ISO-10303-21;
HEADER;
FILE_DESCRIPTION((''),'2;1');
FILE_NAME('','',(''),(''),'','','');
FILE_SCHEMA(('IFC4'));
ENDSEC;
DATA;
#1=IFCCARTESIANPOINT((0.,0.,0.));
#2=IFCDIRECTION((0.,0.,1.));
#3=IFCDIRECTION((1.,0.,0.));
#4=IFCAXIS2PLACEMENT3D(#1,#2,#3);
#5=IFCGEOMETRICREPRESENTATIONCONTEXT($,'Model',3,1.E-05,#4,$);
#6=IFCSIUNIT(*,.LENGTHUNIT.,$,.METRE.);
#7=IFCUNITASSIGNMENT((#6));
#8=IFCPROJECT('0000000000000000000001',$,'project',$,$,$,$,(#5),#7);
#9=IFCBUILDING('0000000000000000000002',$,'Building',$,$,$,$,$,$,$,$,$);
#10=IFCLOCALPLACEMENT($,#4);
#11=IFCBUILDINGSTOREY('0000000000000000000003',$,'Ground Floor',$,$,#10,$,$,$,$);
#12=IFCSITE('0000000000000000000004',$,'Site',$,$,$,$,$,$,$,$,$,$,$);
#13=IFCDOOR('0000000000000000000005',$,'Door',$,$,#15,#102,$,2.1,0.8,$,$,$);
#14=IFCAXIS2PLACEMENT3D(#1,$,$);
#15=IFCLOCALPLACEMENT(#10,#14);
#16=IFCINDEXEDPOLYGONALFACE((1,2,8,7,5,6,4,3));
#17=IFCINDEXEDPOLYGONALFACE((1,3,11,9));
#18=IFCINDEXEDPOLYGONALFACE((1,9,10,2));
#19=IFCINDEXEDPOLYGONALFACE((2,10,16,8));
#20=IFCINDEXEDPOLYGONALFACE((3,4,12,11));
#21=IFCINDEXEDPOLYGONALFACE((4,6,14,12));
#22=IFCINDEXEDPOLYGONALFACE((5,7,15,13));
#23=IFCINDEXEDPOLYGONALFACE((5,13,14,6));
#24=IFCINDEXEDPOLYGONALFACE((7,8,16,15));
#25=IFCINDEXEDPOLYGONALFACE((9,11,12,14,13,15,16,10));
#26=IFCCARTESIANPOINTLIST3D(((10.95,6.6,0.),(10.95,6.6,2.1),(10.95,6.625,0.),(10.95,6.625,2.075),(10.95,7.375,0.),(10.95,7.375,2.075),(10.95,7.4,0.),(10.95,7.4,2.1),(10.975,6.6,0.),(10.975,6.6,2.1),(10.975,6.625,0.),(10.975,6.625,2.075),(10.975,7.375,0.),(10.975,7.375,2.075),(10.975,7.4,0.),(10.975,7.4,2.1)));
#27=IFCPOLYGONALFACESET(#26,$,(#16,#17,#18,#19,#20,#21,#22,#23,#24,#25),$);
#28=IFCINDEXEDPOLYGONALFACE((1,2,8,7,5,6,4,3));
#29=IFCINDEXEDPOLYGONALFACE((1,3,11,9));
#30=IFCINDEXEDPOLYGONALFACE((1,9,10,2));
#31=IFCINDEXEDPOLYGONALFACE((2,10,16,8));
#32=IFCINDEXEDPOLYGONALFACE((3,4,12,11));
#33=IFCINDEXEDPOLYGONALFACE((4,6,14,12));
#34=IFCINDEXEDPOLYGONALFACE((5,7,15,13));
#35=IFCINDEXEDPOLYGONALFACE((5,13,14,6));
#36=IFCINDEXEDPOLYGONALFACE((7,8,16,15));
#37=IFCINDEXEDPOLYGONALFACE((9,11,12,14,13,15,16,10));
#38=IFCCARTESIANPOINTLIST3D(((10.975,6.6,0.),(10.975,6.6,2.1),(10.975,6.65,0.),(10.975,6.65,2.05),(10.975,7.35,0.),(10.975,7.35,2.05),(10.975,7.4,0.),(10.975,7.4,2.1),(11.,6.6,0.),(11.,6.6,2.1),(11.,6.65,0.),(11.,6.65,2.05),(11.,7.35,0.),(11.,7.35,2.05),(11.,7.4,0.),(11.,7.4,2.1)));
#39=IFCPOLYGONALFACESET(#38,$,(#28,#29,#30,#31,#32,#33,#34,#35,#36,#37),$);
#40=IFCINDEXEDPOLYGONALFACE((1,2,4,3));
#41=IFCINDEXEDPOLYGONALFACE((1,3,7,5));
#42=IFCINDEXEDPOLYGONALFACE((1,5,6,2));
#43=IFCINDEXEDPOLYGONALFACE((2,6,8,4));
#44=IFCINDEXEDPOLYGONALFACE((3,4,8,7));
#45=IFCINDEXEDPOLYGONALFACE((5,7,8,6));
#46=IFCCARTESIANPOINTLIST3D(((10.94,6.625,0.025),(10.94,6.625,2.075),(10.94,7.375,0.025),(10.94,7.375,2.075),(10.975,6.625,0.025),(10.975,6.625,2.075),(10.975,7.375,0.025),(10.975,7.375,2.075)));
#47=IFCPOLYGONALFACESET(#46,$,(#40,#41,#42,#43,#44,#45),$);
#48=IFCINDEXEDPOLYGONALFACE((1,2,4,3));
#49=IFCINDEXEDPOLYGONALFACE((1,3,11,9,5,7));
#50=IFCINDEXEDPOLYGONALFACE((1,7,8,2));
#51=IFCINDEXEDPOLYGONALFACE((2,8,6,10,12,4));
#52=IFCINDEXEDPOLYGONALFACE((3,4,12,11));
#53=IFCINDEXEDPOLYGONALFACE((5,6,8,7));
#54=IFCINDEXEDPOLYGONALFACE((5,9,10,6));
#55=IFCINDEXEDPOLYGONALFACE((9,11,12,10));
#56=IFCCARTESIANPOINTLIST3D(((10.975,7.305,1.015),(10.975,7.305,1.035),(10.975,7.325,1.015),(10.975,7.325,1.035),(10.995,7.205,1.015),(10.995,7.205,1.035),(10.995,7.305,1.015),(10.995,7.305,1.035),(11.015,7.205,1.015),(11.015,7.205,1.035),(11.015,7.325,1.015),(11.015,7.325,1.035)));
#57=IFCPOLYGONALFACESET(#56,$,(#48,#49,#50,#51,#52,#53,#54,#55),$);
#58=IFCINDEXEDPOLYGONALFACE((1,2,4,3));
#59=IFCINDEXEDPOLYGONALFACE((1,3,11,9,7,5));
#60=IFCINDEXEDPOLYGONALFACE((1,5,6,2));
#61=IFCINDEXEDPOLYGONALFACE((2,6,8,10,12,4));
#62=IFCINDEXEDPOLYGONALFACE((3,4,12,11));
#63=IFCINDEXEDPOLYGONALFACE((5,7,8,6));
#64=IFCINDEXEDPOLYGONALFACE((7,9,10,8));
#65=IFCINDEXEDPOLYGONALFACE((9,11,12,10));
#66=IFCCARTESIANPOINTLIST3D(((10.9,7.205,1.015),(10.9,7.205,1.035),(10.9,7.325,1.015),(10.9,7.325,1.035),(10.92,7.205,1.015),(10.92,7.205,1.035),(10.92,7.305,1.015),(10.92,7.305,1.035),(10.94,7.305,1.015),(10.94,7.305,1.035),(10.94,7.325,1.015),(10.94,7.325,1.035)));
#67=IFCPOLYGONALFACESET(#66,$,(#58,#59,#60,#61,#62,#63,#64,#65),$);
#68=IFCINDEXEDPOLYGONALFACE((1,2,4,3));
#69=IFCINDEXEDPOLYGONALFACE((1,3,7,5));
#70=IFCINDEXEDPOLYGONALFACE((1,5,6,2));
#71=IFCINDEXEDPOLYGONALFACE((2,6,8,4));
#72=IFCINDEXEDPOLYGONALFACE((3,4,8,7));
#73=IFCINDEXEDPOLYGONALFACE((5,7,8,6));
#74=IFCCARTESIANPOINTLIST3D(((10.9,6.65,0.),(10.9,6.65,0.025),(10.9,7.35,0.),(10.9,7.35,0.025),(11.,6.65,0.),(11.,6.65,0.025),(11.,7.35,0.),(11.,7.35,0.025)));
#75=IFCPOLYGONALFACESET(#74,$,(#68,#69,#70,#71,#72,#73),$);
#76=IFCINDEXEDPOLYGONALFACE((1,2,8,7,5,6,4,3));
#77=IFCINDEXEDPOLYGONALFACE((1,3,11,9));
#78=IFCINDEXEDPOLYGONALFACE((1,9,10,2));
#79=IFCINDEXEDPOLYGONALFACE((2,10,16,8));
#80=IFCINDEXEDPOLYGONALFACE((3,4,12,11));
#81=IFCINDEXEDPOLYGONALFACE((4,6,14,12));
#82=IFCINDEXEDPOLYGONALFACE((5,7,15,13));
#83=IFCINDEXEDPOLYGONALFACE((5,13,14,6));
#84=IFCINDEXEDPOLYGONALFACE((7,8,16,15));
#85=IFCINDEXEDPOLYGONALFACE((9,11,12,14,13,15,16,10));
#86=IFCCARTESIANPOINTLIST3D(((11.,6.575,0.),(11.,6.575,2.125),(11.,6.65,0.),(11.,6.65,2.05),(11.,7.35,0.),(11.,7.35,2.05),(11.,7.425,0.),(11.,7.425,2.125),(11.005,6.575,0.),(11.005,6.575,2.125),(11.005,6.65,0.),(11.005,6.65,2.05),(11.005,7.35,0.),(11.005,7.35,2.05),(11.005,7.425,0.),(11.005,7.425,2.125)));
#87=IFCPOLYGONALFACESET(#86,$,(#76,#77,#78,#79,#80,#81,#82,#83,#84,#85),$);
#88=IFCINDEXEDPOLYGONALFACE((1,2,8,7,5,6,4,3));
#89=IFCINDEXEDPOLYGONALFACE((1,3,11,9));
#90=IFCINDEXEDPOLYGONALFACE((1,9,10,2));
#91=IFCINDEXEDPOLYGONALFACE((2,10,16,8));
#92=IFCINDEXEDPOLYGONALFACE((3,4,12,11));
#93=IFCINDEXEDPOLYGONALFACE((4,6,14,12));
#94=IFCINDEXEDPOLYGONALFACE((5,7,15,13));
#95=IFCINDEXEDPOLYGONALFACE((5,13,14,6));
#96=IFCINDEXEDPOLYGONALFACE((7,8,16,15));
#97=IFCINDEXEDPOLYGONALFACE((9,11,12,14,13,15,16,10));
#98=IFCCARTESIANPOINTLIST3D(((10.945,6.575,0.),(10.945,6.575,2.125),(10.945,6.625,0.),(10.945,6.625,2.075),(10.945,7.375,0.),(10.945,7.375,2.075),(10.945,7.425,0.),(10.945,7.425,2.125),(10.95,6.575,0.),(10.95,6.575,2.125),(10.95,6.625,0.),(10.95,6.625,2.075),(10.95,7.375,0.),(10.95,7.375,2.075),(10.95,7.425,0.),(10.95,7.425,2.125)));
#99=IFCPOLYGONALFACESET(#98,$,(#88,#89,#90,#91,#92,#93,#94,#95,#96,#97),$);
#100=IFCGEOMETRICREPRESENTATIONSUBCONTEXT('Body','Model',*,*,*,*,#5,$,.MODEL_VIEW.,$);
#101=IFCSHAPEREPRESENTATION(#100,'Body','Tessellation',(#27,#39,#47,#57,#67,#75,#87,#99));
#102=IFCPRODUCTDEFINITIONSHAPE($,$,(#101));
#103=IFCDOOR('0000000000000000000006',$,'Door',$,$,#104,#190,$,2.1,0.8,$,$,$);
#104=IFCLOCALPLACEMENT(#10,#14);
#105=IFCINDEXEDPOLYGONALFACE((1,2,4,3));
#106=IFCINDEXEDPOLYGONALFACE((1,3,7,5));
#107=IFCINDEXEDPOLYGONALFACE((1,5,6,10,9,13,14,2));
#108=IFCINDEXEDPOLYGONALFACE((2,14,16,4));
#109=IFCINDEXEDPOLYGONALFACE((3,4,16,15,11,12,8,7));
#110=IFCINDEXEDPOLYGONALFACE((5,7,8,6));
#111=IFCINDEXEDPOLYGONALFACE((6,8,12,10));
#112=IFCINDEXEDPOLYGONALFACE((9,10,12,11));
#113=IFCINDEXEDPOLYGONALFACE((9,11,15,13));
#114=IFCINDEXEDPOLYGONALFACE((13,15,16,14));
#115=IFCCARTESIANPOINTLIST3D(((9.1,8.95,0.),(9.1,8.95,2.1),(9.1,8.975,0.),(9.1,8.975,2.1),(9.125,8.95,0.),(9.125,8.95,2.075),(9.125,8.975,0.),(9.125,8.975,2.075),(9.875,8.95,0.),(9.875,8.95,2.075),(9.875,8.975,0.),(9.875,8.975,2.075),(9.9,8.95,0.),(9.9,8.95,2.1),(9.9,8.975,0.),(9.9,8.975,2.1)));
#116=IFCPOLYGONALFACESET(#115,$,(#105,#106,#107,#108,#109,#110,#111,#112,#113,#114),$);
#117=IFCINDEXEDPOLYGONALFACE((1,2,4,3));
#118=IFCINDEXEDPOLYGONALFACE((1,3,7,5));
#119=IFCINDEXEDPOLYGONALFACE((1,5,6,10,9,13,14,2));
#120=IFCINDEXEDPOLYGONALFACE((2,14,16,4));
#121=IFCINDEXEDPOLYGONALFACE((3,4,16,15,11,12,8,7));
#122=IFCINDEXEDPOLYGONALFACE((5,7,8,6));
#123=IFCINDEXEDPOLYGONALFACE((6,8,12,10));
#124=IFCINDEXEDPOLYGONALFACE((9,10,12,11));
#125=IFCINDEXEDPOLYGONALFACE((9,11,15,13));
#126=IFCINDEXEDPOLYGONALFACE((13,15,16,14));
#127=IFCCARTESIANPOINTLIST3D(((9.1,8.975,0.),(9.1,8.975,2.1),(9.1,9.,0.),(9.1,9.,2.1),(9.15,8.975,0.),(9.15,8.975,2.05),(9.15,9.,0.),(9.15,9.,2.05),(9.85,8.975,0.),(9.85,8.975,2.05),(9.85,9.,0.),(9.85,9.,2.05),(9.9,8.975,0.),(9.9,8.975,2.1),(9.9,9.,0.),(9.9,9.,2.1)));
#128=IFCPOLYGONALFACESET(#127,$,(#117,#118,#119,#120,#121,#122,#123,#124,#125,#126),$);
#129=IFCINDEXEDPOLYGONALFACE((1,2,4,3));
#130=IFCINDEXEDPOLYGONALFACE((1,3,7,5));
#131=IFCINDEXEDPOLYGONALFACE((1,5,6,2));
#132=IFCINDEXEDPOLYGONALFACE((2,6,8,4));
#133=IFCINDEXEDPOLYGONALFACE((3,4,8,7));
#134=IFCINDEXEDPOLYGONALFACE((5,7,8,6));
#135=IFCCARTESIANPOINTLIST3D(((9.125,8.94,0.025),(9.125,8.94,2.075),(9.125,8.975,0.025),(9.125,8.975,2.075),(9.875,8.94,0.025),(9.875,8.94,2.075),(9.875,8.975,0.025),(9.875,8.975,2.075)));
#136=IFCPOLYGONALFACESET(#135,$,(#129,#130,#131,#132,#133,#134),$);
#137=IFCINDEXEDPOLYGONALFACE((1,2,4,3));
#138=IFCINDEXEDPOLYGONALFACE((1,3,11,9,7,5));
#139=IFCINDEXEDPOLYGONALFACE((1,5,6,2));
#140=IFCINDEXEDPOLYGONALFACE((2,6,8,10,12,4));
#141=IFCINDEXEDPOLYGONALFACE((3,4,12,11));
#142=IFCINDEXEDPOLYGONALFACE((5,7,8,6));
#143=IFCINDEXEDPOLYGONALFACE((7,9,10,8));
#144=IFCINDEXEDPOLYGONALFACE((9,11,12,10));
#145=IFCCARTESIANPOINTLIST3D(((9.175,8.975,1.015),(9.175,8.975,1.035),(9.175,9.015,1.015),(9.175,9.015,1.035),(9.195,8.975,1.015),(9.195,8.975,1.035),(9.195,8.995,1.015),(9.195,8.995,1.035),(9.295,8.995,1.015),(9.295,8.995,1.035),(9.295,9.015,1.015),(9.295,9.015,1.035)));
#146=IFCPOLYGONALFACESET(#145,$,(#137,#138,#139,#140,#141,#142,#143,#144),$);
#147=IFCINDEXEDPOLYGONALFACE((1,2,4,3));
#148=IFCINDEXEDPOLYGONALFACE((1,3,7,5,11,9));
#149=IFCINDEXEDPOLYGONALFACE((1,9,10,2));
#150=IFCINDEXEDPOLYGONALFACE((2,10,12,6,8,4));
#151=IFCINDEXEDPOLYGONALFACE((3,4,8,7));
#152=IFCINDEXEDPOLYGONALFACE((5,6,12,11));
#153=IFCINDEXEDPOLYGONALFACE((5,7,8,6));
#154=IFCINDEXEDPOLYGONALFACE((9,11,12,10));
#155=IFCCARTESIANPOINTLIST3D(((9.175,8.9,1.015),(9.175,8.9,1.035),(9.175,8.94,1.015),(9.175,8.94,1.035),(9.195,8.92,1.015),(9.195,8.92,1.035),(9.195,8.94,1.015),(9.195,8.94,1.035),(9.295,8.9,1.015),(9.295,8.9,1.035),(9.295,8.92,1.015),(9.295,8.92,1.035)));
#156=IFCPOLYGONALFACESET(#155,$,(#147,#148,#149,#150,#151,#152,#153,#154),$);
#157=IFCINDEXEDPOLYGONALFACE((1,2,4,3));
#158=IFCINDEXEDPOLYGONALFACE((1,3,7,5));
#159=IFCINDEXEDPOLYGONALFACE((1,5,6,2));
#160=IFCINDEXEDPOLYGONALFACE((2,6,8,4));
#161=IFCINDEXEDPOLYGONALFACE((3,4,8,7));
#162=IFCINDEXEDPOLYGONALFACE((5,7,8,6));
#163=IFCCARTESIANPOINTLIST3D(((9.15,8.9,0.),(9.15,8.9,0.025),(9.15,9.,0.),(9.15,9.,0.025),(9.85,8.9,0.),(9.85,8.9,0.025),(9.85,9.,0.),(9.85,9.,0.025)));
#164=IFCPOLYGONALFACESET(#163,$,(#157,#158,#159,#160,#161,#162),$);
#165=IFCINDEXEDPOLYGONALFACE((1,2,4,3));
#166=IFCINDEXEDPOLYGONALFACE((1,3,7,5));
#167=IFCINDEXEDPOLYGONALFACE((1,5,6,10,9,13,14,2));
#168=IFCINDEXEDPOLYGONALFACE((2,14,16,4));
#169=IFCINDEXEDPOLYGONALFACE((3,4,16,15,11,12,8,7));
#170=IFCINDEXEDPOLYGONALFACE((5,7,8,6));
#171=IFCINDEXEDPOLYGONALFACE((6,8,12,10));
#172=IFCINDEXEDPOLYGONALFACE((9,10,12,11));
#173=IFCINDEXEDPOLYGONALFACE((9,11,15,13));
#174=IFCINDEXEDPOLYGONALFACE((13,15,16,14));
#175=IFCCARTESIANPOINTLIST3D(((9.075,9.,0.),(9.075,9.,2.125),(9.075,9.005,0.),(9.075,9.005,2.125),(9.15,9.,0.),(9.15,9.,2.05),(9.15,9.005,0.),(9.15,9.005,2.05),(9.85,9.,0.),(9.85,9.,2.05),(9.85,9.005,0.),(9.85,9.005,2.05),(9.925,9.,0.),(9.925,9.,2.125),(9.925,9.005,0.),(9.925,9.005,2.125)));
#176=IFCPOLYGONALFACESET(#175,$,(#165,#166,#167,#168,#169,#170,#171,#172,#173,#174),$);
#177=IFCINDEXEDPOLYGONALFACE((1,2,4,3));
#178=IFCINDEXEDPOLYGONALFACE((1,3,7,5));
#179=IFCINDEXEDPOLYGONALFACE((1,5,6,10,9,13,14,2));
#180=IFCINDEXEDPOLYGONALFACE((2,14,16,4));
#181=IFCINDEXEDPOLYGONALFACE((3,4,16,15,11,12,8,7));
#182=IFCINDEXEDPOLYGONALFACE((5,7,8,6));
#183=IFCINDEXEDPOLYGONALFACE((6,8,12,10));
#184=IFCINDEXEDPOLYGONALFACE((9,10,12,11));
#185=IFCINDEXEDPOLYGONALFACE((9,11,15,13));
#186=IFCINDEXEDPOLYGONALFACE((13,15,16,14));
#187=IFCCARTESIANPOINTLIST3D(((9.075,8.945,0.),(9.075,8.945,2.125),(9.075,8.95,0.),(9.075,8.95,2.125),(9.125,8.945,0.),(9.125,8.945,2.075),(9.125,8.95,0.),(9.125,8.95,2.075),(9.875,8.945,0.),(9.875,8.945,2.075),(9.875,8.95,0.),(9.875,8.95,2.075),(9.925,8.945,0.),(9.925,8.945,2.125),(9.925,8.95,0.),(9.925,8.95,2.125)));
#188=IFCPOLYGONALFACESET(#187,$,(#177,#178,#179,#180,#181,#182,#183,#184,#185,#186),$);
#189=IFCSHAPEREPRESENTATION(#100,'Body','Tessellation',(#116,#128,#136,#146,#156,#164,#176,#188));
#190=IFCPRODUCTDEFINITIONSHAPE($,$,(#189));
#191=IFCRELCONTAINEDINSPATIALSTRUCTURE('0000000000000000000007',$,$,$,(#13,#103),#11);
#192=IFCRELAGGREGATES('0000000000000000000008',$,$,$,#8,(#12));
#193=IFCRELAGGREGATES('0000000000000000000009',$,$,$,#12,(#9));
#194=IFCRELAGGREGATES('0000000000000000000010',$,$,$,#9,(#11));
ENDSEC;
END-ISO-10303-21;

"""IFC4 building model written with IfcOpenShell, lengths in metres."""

from ifc_helpers import new_model, si_unit, frame, origin_with_axes, place, context, subcontext, project, spatial, line, indexed_curve, outline, extrude, element, save


model = new_model("IFC4")

# Units and contexts
model_context = context("Model", 3, precision=1e-05, world=origin_with_axes())
body_context = subcontext(model_context, "Body", "Model", "MODEL_VIEW")
ifc_project = project(units=[si_unit("LENGTHUNIT", "METRE")], contexts=[model_context])

# Site, building, storey
site = spatial("IfcSite", under=ifc_project, Name="Site")
building = spatial("IfcBuilding", under=site, Name="Building")
storey_placement = place(None, origin_with_axes())
storey = spatial("IfcBuildingStorey", under=building, at=storey_placement, Name="Ground Floor")

# Doors
door_1_placement = place(storey_placement, frame((11.0, 6.6, 0.0), z_axis=(0.0, 0.0, 1.0), x_axis=(0.0, 1.0, 0.0)))
element("IfcDoor", 1, at=door_1_placement, inside=storey, Name="Door", OverallHeight=2.1, OverallWidth=0.8, context=body_context, shape_type="SweptSolid", body=[
    extrude(outline(indexed_curve([(0.0, 0.0), (0.0, 2.1), (0.8, 2.1), (0.8, 0.0), (0.775, 0.0), (0.775, 2.075), (0.025, 2.075), (0.025, 0.0)], segments=[line(1, 2, 3, 4, 5, 6, 7, 8, 1)])), frame((0.0, 0.025, 0.0), z_axis=(0.0, -1.0, 0.0), x_axis=(1.0, 0.0, 0.0)), (0.0, 0.0, -1.0), 0.025),
    extrude(outline(indexed_curve([(0.0, 0.0), (0.0, 2.1), (0.8, 2.1), (0.8, 0.0), (0.75, 0.0), (0.75, 2.05), (0.05, 2.05), (0.05, 0.0)], segments=[line(1, 2, 3, 4, 5, 6, 7, 8, 1)])), frame((0.0, 0.0, 0.0), z_axis=(0.0, -1.0, 0.0), x_axis=(1.0, 0.0, 0.0)), (0.0, 0.0, -1.0), 0.025),
    extrude(outline(indexed_curve([(0.0, 0.0), (0.75, 0.0), (0.75, 0.035), (0.0, 0.035)], segments=[line(1, 2, 3, 4, 1)])), frame((0.025, 0.025, 0.025), z_axis=(0.0, 0.0, 1.0), x_axis=(1.0, 0.0, 0.0)), (0.0, 0.0, 1.0), 2.05),
    extrude(outline(indexed_curve([(0.0, 0.0), (0.0, -0.04), (-0.12, -0.04), (-0.12, -0.02), (-0.02, -0.02), (-0.02, 0.0)], segments=[line(1, 2, 3, 4, 5, 6, 1)])), frame((0.725, 0.025, 1.015), z_axis=(0.0, 0.0, 1.0), x_axis=(1.0, 0.0, 0.0)), (0.0, 0.0, 1.0), 0.02),
    extrude(outline(indexed_curve([(0.0, 0.0), (0.0, 0.04), (-0.12, 0.04), (-0.12, 0.02), (-0.02, 0.02), (-0.02, 0.0)], segments=[line(1, 2, 3, 4, 5, 6, 1)])), frame((0.725, 0.06, 1.015), z_axis=(0.0, 0.0, 1.0), x_axis=(1.0, 0.0, 0.0)), (0.0, 0.0, 1.0), 0.02),
    extrude(outline(indexed_curve([(0.0, 0.0), (0.7, 0.0), (0.7, 0.1), (0.0, 0.1)], segments=[line(1, 2, 3, 4, 1)])), frame((0.05, 0.0, 0.0), z_axis=(0.0, 0.0, 1.0), x_axis=(1.0, 0.0, 0.0)), (0.0, 0.0, 1.0), 0.025),
    extrude(outline(indexed_curve([(0.0, 0.0), (0.0, 2.125), (0.85, 2.125), (0.85, 0.0), (0.775, 0.0), (0.775, 2.05), (0.075, 2.05), (0.075, 0.0)], segments=[line(1, 2, 3, 4, 5, 6, 7, 8, 1)])), frame((-0.025, -0.005, 0.0), z_axis=(0.0, -1.0, 0.0), x_axis=(1.0, 0.0, 0.0)), (0.0, 0.0, -1.0), 0.005),
    extrude(outline(indexed_curve([(0.0, 0.0), (0.0, 2.125), (0.85, 2.125), (0.85, 0.0), (0.8, 0.0), (0.8, 2.075), (0.05, 2.075), (0.05, 0.0)], segments=[line(1, 2, 3, 4, 5, 6, 7, 8, 1)])), frame((-0.025, 0.05, 0.0), z_axis=(0.0, -1.0, 0.0), x_axis=(1.0, 0.0, 0.0)), (0.0, 0.0, -1.0), 0.005),
])
door_2_placement = place(storey_placement, frame((9.9, 9.0, 0.0), z_axis=(0.0, 0.0, 1.0), x_axis=(-1.0, 0.0, 0.0)))
element("IfcDoor", 2, at=door_2_placement, inside=storey, Name="Door", OverallHeight=2.1, OverallWidth=0.8, context=body_context, shape_type="SweptSolid", body=[
    extrude(outline(indexed_curve([(0.0, 0.0), (0.0, 2.1), (0.8, 2.1), (0.8, 0.0), (0.775, 0.0), (0.775, 2.075), (0.025, 2.075), (0.025, 0.0)], segments=[line(1, 2, 3, 4, 5, 6, 7, 8, 1)])), frame((0.0, 0.025, 0.0), z_axis=(0.0, -1.0, 0.0), x_axis=(1.0, 0.0, 0.0)), (0.0, 0.0, -1.0), 0.025),
    extrude(outline(indexed_curve([(0.0, 0.0), (0.0, 2.1), (0.8, 2.1), (0.8, 0.0), (0.75, 0.0), (0.75, 2.05), (0.05, 2.05), (0.05, 0.0)], segments=[line(1, 2, 3, 4, 5, 6, 7, 8, 1)])), frame((0.0, 0.0, 0.0), z_axis=(0.0, -1.0, 0.0), x_axis=(1.0, 0.0, 0.0)), (0.0, 0.0, -1.0), 0.025),
    extrude(outline(indexed_curve([(0.0, 0.0), (0.75, 0.0), (0.75, 0.035), (0.0, 0.035)], segments=[line(1, 2, 3, 4, 1)])), frame((0.025, 0.025, 0.025), z_axis=(0.0, 0.0, 1.0), x_axis=(1.0, 0.0, 0.0)), (0.0, 0.0, 1.0), 2.05),
    extrude(outline(indexed_curve([(0.0, 0.0), (0.0, -0.04), (-0.12, -0.04), (-0.12, -0.02), (-0.02, -0.02), (-0.02, 0.0)], segments=[line(1, 2, 3, 4, 5, 6, 1)])), frame((0.725, 0.025, 1.015), z_axis=(0.0, 0.0, 1.0), x_axis=(1.0, 0.0, 0.0)), (0.0, 0.0, 1.0), 0.02),
    extrude(outline(indexed_curve([(0.0, 0.0), (0.0, 0.04), (-0.12, 0.04), (-0.12, 0.02), (-0.02, 0.02), (-0.02, 0.0)], segments=[line(1, 2, 3, 4, 5, 6, 1)])), frame((0.725, 0.06, 1.015), z_axis=(0.0, 0.0, 1.0), x_axis=(1.0, 0.0, 0.0)), (0.0, 0.0, 1.0), 0.02),
    extrude(outline(indexed_curve([(0.0, 0.0), (0.7, 0.0), (0.7, 0.1), (0.0, 0.1)], segments=[line(1, 2, 3, 4, 1)])), frame((0.05, 0.0, 0.0), z_axis=(0.0, 0.0, 1.0), x_axis=(1.0, 0.0, 0.0)), (0.0, 0.0, 1.0), 0.025),
    extrude(outline(indexed_curve([(0.0, 0.0), (0.0, 2.125), (0.85, 2.125), (0.85, 0.0), (0.775, 0.0), (0.775, 2.05), (0.075, 2.05), (0.075, 0.0)], segments=[line(1, 2, 3, 4, 5, 6, 7, 8, 1)])), frame((-0.025, -0.005, 0.0), z_axis=(0.0, -1.0, 0.0), x_axis=(1.0, 0.0, 0.0)), (0.0, 0.0, -1.0), 0.005),
    extrude(outline(indexed_curve([(0.0, 0.0), (0.0, 2.125), (0.85, 2.125), (0.85, 0.0), (0.8, 0.0), (0.8, 2.075), (0.05, 2.075), (0.05, 0.0)], segments=[line(1, 2, 3, 4, 5, 6, 7, 8, 1)])), frame((-0.025, 0.05, 0.0), z_axis=(0.0, -1.0, 0.0), x_axis=(1.0, 0.0, 0.0)), (0.0, 0.0, -1.0), 0.005),
])

save(model, "model.ifc")
